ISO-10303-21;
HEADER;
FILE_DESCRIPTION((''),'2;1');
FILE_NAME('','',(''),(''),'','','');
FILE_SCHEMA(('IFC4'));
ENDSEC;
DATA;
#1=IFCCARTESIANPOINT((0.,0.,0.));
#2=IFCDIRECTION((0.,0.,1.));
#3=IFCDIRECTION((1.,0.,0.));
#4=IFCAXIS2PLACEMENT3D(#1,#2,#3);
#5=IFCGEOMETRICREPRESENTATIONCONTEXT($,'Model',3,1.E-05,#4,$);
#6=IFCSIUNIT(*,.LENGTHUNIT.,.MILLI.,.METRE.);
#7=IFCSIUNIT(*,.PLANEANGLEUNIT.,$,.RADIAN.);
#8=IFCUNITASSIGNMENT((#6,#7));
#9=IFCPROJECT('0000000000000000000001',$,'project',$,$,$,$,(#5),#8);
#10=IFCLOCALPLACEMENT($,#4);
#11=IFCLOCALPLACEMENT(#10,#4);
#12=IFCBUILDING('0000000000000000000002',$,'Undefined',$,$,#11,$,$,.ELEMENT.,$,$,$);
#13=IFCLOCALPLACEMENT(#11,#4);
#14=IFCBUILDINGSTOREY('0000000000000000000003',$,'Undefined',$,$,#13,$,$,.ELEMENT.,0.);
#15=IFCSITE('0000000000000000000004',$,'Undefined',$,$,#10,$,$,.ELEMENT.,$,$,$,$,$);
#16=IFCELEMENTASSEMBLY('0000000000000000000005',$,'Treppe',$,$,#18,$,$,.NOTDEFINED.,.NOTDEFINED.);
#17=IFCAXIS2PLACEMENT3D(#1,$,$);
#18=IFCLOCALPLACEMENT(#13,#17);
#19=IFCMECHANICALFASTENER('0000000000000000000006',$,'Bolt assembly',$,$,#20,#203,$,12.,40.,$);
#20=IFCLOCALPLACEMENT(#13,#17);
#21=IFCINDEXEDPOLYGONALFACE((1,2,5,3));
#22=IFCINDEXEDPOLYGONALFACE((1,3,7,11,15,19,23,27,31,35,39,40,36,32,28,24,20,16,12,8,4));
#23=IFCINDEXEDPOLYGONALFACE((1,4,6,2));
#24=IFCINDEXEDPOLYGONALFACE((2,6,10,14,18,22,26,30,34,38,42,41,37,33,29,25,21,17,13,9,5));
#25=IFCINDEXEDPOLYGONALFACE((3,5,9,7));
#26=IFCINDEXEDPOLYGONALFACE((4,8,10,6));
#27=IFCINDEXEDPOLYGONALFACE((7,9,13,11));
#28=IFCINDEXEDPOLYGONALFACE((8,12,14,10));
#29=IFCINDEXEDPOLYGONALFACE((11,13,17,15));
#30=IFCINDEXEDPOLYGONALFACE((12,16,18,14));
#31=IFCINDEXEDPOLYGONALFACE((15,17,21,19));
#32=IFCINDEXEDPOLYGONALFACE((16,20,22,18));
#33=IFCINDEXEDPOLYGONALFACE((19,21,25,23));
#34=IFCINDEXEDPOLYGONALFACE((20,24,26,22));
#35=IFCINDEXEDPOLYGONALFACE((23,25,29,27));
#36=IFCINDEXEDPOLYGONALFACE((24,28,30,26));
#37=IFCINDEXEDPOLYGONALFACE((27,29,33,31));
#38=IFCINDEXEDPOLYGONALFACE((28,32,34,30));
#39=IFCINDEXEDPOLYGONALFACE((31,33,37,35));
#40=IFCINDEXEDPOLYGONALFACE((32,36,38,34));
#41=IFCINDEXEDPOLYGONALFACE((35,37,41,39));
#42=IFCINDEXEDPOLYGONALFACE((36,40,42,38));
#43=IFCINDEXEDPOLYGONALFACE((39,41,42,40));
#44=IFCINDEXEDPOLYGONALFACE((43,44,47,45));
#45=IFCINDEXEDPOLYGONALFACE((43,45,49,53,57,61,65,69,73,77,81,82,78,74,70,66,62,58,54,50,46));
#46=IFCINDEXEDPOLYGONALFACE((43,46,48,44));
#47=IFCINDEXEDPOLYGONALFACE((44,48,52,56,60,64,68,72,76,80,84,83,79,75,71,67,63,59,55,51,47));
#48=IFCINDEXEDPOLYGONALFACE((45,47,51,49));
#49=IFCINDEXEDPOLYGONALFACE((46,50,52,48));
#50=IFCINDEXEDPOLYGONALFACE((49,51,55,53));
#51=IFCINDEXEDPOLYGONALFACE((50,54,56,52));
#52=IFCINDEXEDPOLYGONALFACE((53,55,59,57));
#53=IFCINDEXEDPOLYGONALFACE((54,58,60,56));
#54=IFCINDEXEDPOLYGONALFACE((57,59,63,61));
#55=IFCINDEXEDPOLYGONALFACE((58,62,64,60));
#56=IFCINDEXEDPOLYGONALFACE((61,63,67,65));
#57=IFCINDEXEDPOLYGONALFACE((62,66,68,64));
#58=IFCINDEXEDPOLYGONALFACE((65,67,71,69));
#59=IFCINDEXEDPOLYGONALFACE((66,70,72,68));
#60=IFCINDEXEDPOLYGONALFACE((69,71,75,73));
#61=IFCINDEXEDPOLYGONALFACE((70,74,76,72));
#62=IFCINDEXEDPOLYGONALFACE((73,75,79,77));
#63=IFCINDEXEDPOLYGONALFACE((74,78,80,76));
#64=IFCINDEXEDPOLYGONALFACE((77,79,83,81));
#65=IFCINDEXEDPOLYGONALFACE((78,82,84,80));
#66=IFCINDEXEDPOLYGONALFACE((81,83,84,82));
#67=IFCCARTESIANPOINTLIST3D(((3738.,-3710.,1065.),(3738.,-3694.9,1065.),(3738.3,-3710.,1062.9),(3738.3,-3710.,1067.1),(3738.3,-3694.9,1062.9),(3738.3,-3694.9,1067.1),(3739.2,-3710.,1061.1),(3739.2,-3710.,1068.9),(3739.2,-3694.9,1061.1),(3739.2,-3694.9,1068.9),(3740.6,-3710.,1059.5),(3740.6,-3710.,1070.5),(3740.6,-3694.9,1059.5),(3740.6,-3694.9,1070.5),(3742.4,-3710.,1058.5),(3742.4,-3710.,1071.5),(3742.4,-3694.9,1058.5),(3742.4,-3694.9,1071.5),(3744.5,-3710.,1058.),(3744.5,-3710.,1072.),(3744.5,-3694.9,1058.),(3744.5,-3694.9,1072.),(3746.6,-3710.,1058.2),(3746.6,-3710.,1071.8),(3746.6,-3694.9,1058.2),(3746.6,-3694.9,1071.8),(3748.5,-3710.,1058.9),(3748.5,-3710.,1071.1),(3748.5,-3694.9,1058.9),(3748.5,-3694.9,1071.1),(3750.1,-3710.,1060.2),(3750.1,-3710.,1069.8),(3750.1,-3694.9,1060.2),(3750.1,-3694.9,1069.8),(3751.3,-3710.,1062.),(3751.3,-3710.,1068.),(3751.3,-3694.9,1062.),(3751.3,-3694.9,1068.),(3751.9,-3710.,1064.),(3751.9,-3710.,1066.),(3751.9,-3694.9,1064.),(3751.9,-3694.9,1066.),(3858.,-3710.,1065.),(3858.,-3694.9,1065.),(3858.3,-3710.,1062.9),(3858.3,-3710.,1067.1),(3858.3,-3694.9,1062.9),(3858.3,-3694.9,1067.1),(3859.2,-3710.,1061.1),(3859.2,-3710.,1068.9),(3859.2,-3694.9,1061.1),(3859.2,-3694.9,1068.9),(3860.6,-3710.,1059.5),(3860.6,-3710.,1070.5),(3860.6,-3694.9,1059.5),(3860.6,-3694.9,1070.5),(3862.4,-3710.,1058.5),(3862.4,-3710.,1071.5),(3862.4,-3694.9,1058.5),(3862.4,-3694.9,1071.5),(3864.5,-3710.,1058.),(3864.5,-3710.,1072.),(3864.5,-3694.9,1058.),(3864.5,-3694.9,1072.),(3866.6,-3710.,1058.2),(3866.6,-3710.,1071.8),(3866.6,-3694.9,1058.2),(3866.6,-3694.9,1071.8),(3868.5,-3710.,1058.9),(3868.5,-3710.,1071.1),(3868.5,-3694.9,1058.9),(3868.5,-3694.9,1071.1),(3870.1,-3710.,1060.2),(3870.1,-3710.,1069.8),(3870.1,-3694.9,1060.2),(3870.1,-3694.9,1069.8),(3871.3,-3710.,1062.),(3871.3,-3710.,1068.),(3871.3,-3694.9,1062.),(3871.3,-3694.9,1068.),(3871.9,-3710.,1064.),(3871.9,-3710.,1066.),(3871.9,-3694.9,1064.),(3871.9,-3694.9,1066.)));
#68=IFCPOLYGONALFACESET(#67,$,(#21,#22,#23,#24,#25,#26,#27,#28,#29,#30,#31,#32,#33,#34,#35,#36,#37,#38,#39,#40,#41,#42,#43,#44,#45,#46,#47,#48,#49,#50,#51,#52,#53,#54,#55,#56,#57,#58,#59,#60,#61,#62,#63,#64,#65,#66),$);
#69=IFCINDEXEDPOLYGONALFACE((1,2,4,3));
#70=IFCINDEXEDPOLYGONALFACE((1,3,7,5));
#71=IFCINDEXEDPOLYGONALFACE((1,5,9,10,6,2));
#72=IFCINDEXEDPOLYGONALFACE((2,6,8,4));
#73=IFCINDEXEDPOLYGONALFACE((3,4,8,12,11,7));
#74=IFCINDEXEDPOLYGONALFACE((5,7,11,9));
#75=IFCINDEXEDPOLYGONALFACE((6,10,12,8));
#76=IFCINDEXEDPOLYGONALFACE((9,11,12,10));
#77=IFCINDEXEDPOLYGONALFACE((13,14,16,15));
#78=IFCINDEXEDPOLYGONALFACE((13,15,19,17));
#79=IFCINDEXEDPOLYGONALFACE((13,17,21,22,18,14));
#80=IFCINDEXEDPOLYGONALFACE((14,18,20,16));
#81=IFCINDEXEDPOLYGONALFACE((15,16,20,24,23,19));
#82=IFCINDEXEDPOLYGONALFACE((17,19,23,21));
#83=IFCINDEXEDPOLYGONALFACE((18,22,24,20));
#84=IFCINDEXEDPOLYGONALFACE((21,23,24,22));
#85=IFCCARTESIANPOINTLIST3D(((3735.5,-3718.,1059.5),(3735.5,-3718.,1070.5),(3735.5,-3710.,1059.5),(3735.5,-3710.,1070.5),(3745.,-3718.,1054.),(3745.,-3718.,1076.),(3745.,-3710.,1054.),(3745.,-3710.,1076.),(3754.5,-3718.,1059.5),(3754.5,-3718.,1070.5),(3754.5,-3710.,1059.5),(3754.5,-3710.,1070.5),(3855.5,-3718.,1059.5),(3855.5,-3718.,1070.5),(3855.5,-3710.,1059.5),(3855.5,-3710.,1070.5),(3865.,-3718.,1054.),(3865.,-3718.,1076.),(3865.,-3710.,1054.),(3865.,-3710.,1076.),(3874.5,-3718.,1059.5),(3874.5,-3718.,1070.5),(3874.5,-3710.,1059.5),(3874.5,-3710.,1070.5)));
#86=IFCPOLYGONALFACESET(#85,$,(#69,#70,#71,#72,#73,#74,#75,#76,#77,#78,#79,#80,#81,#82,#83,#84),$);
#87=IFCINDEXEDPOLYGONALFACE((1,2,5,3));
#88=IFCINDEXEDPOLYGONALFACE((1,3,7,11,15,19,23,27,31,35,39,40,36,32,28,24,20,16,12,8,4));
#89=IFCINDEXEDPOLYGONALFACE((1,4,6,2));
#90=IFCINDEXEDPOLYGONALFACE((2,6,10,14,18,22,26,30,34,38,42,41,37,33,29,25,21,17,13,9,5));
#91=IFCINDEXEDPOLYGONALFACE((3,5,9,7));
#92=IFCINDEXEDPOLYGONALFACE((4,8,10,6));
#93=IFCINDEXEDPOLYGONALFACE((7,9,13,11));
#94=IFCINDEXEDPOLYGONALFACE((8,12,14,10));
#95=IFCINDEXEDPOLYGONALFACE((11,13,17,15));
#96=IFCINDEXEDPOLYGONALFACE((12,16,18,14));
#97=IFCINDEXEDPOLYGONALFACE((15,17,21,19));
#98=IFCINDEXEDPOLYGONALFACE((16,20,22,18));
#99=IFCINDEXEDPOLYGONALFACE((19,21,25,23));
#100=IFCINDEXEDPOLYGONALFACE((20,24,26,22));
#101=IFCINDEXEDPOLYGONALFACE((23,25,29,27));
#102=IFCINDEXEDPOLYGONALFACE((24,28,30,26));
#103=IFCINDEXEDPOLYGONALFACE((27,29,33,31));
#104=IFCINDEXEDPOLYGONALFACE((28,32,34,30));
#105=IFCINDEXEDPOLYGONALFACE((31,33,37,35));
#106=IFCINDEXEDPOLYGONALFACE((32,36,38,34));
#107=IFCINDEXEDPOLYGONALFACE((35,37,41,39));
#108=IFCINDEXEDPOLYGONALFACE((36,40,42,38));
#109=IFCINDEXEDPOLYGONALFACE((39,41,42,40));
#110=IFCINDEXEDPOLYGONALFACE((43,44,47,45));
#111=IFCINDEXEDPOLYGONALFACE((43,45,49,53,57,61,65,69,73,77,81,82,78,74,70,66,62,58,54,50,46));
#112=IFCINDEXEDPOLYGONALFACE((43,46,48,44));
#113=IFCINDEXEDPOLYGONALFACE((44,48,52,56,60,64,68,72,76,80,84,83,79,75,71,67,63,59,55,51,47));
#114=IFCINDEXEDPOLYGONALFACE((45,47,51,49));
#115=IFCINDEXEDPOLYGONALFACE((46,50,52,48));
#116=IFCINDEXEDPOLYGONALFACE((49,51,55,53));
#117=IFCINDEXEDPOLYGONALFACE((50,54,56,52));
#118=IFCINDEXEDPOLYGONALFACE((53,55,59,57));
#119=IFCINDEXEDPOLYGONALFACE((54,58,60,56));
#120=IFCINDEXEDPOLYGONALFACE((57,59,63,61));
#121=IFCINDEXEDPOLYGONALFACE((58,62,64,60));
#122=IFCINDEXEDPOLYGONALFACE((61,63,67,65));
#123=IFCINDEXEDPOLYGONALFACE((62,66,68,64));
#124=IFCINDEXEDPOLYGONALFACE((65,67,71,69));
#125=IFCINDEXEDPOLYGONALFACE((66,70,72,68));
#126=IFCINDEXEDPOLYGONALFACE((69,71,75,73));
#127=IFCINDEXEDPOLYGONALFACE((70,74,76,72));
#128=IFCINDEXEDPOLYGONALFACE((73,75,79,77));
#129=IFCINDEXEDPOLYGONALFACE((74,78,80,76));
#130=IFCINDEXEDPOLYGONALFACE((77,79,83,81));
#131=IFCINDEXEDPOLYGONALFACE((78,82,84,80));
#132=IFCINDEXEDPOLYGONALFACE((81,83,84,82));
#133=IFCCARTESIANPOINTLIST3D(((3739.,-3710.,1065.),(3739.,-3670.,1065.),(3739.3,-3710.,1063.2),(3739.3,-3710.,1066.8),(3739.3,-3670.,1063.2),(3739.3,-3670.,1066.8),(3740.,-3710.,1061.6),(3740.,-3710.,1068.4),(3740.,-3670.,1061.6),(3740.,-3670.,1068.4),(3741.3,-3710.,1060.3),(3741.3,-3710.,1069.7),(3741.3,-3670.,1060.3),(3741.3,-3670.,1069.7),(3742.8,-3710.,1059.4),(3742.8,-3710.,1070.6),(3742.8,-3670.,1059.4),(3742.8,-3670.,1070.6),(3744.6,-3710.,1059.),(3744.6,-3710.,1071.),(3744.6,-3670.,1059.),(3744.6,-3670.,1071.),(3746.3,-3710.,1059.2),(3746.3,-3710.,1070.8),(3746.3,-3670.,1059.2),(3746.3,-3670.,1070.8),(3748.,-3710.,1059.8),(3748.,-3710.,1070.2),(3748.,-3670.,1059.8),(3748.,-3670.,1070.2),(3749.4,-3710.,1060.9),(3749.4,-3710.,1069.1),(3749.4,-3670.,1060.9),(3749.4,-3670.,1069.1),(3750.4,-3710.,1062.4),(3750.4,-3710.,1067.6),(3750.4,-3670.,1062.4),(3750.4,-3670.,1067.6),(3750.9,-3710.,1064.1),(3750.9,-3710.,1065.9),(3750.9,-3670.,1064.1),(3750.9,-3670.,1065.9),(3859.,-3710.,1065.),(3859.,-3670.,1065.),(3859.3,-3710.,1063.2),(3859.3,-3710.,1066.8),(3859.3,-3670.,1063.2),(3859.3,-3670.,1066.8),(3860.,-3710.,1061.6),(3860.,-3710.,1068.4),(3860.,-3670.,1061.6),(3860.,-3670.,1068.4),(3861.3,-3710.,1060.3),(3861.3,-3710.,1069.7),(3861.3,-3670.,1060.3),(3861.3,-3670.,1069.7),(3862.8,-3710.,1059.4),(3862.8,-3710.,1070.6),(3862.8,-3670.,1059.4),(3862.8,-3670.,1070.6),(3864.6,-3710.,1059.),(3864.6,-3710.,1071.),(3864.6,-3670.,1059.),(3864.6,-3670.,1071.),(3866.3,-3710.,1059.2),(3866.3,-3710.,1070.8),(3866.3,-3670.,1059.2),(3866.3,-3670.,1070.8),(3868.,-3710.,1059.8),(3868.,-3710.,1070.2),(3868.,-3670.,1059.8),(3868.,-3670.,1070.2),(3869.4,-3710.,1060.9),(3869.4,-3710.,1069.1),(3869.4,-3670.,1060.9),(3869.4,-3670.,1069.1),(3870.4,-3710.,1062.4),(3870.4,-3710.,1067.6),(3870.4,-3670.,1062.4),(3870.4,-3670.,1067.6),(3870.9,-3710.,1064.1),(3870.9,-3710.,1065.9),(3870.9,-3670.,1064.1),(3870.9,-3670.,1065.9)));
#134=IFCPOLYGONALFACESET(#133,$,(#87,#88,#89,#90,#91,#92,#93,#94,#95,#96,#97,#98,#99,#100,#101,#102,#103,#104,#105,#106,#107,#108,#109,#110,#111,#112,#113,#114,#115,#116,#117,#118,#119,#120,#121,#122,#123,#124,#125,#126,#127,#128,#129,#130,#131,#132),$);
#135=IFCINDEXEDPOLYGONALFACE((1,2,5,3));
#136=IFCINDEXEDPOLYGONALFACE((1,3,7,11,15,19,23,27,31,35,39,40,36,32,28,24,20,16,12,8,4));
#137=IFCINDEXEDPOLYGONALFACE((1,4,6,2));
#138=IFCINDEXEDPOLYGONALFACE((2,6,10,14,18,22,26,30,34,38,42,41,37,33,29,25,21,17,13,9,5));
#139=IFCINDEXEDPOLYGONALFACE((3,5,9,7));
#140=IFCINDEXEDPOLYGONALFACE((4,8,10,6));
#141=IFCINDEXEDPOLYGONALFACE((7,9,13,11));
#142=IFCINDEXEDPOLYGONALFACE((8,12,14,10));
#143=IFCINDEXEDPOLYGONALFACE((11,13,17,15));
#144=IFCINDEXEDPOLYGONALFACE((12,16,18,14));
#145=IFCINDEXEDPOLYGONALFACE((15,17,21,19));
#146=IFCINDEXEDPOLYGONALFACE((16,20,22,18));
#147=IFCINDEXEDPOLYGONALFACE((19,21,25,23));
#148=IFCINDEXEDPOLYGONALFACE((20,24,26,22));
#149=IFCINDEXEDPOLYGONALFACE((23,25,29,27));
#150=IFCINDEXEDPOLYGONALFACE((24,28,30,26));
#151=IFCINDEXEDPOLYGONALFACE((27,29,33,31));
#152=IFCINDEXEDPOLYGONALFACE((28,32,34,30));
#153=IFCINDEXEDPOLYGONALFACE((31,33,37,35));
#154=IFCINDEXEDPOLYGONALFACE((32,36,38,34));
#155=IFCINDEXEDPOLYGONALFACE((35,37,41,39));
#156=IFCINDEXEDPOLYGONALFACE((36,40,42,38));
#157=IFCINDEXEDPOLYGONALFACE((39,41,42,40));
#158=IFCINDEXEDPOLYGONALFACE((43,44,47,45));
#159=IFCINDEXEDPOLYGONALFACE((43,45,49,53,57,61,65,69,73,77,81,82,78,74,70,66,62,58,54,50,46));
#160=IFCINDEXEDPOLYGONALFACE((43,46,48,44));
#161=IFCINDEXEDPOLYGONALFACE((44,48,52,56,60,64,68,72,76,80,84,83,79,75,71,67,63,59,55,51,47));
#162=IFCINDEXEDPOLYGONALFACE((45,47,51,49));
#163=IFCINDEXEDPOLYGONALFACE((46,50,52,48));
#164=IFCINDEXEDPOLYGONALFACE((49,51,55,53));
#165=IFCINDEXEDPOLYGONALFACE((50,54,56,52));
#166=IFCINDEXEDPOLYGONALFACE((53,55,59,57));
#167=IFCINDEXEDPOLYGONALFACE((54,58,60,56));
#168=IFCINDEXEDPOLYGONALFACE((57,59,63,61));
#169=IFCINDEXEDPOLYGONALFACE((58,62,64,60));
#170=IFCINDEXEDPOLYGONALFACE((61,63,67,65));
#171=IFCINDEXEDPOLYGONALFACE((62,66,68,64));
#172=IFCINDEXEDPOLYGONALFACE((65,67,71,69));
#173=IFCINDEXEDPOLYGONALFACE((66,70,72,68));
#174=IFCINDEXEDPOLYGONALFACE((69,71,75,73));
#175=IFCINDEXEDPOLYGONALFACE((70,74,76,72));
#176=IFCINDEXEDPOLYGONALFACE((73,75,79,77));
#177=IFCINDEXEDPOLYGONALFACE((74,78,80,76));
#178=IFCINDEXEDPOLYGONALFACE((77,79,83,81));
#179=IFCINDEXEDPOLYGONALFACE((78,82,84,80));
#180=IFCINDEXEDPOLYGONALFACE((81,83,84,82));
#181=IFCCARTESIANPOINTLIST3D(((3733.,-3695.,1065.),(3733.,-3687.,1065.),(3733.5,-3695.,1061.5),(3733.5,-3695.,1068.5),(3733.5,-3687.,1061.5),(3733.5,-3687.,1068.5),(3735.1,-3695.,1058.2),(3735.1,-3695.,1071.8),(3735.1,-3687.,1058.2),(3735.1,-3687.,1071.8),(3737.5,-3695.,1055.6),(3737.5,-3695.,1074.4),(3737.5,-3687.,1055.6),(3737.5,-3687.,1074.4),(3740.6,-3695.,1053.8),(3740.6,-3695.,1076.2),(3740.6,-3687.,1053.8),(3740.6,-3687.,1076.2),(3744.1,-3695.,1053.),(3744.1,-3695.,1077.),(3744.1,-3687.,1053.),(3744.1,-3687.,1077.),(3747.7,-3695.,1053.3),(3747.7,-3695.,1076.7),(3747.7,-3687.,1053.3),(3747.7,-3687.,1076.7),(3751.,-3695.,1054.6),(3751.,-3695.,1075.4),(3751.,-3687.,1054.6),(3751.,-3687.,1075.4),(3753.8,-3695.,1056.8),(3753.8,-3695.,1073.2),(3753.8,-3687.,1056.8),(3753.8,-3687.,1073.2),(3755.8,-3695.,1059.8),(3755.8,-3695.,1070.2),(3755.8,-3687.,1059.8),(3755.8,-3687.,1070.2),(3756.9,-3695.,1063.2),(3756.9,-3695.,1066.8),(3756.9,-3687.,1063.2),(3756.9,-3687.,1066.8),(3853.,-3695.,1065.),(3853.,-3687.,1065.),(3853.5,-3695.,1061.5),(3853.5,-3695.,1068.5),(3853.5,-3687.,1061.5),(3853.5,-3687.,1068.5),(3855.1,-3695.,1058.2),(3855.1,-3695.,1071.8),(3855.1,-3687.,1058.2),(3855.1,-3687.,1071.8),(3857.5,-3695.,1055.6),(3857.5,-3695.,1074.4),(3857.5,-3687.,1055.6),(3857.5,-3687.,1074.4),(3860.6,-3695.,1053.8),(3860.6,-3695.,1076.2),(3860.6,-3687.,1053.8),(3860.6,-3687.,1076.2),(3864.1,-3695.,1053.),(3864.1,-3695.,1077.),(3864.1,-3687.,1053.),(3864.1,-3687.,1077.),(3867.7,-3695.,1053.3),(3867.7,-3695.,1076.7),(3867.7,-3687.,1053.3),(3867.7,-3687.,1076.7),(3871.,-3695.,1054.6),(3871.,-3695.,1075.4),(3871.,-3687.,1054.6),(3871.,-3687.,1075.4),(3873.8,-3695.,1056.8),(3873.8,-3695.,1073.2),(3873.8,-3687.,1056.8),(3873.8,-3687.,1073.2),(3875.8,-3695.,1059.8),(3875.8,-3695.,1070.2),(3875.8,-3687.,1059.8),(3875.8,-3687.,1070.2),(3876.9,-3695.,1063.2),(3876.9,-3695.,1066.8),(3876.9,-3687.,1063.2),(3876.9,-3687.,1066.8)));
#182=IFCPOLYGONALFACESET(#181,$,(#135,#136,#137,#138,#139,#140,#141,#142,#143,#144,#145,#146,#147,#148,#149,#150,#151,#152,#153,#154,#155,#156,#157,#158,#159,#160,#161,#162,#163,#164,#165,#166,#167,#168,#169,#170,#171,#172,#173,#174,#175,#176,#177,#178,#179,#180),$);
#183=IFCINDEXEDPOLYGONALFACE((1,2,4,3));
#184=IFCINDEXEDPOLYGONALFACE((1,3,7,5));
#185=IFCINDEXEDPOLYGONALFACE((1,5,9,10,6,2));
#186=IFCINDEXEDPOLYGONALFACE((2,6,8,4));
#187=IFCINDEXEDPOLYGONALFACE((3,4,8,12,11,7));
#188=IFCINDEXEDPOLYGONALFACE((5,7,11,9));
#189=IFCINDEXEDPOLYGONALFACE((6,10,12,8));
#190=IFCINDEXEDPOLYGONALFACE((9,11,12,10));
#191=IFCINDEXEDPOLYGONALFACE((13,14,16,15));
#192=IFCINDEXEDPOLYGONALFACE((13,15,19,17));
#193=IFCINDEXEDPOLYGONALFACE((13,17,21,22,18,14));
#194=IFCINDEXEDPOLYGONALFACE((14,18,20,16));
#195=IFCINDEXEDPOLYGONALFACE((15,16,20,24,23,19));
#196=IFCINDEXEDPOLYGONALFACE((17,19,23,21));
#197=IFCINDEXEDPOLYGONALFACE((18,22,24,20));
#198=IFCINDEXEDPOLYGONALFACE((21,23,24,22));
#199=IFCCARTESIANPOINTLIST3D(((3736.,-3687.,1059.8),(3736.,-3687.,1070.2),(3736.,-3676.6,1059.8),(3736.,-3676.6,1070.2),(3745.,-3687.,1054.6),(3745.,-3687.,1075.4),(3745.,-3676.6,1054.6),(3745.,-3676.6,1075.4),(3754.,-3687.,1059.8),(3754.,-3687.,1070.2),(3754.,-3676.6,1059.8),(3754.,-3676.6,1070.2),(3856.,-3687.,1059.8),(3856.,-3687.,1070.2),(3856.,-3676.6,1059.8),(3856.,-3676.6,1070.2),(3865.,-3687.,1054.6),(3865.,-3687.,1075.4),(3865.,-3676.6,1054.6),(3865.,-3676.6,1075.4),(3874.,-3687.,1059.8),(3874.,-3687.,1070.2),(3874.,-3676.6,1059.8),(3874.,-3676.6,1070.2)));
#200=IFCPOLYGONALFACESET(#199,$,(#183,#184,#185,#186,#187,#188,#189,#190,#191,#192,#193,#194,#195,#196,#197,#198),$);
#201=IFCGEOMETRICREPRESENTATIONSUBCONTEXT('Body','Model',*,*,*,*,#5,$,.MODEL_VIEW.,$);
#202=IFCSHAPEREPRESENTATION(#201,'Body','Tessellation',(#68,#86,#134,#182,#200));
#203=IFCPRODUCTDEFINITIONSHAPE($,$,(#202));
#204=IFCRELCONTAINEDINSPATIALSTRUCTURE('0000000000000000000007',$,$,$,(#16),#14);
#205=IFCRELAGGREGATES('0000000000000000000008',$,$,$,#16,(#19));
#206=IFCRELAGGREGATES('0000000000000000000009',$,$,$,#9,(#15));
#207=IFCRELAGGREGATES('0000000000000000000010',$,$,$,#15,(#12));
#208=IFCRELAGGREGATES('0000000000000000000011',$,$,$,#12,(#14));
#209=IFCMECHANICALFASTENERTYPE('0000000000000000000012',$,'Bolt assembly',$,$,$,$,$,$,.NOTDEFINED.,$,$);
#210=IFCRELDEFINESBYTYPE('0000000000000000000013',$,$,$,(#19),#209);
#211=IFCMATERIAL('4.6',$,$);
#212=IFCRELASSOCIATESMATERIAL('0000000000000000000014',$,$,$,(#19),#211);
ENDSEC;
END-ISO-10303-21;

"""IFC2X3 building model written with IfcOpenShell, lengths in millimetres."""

from ifc_helpers import new_model, si_unit, frame, origin_with_axes, origin_2d_with_axis, place, context, subcontext, project, spatial, polyline, circle, outline, extrude, source, transform, mapped, material, type_object, element, aggregate, save


model = new_model("IFC2X3")

# Units and contexts
model_context = context("Model", 3, precision=1e-05, world=origin_with_axes())
body_context = subcontext(model_context, "Body", "Model", "MODEL_VIEW")
ifc_project = project(units=[si_unit("LENGTHUNIT", "METRE", prefix="MILLI"), si_unit("PLANEANGLEUNIT", "RADIAN")], contexts=[model_context])

# Site, building, storey
site_placement = place(None, origin_with_axes())
site = spatial("IfcSite", under=ifc_project, at=site_placement, Name="Undefined", CompositionType="ELEMENT")
building_placement = place(site_placement, origin_with_axes())
building = spatial("IfcBuilding", under=site, at=building_placement, Name="Undefined", CompositionType="ELEMENT")
storey_placement = place(building_placement, origin_with_axes())
storey = spatial("IfcBuildingStorey", under=building, at=storey_placement, Name="Undefined", CompositionType="ELEMENT", Elevation=0.0)

# Element assembly, mechanical fastener
assembly_1_placement = place(storey_placement, origin_with_axes())
assembly_1 = element("IfcElementAssembly", 1, at=assembly_1_placement, inside=storey, Name="Treppe", AssemblyPlace="NOTDEFINED", PredefinedType="NOTDEFINED")
ifc_material_1 = material(Name="4.6")
mechanical_fastener_type = type_object("IfcMechanicalFastenerType", Name="Bolt assembly")
shared_shape_1 = source(origin_with_axes(), body_context, "Body", "SweptSolid", [
    extrude(circle(Radius=7.0, at=origin_2d_with_axis()), frame((0.0, 0.0, 0.0), z_axis=(0.0, 1.0, 0.0), x_axis=(1.0, 0.0, 0.0)), (0.0, 0.0, 1.0), 15.1),
    extrude(outline(polyline([(9.5, -5.5), (9.5, 5.5), (0.0, 11.0), (-9.5, 5.5), (-9.5, -5.5), (0.0, -11.0), (9.5, -5.5)])), frame((0.0, -8.0, 0.0), z_axis=(0.0, 1.0, 0.0), x_axis=(1.0, 0.0, 0.0)), (0.0, 0.0, 1.0), 8.0),
    extrude(circle(Radius=6.0, at=origin_2d_with_axis()), frame((0.0, 0.0, 0.0), z_axis=(0.0, 1.0, 0.0), x_axis=(1.0, 0.0, 0.0)), (0.0, 0.0, 1.0), 40.0),
    extrude(circle(Radius=12.0, at=origin_2d_with_axis()), frame((0.0, 15.0, 0.0), z_axis=(0.0, 1.0, 0.0), x_axis=(1.0, 0.0, 0.0)), (0.0, 0.0, 1.0), 8.0),
    extrude(outline(polyline([(9.0, -5.2), (9.0, 5.2), (0.0, 10.4), (-9.0, 5.2), (-9.0, -5.2), (0.0, -10.4), (9.0, -5.2)])), frame((0.0, 23.0, 0.0), z_axis=(0.0, 1.0, 0.0), x_axis=(1.0, 0.0, 0.0)), (0.0, 0.0, 1.0), 10.4),
])
mechanical_fastener_1_placement = place(assembly_1_placement, frame((3865.0, -3710.0, 1065.0), z_axis=(0.0, 0.0, -1.0), x_axis=(-1.0, 0.0, 0.0)))
mechanical_fastener_1 = element("IfcMechanicalFastener", 2, at=mechanical_fastener_1_placement, type_object=mechanical_fastener_type, material=ifc_material_1, Name="Bolt assembly", NominalDiameter=12.0, NominalLength=40.0, context=body_context, shape_type="MappedRepresentation", body=[
    mapped(shared_shape_1, transform((0.0, 0.0, 0.0))),
    mapped(shared_shape_1, transform((120.0, 0.0, 0.0))),
])
aggregate(assembly_1, [mechanical_fastener_1])

save(model, "model.ifc")
